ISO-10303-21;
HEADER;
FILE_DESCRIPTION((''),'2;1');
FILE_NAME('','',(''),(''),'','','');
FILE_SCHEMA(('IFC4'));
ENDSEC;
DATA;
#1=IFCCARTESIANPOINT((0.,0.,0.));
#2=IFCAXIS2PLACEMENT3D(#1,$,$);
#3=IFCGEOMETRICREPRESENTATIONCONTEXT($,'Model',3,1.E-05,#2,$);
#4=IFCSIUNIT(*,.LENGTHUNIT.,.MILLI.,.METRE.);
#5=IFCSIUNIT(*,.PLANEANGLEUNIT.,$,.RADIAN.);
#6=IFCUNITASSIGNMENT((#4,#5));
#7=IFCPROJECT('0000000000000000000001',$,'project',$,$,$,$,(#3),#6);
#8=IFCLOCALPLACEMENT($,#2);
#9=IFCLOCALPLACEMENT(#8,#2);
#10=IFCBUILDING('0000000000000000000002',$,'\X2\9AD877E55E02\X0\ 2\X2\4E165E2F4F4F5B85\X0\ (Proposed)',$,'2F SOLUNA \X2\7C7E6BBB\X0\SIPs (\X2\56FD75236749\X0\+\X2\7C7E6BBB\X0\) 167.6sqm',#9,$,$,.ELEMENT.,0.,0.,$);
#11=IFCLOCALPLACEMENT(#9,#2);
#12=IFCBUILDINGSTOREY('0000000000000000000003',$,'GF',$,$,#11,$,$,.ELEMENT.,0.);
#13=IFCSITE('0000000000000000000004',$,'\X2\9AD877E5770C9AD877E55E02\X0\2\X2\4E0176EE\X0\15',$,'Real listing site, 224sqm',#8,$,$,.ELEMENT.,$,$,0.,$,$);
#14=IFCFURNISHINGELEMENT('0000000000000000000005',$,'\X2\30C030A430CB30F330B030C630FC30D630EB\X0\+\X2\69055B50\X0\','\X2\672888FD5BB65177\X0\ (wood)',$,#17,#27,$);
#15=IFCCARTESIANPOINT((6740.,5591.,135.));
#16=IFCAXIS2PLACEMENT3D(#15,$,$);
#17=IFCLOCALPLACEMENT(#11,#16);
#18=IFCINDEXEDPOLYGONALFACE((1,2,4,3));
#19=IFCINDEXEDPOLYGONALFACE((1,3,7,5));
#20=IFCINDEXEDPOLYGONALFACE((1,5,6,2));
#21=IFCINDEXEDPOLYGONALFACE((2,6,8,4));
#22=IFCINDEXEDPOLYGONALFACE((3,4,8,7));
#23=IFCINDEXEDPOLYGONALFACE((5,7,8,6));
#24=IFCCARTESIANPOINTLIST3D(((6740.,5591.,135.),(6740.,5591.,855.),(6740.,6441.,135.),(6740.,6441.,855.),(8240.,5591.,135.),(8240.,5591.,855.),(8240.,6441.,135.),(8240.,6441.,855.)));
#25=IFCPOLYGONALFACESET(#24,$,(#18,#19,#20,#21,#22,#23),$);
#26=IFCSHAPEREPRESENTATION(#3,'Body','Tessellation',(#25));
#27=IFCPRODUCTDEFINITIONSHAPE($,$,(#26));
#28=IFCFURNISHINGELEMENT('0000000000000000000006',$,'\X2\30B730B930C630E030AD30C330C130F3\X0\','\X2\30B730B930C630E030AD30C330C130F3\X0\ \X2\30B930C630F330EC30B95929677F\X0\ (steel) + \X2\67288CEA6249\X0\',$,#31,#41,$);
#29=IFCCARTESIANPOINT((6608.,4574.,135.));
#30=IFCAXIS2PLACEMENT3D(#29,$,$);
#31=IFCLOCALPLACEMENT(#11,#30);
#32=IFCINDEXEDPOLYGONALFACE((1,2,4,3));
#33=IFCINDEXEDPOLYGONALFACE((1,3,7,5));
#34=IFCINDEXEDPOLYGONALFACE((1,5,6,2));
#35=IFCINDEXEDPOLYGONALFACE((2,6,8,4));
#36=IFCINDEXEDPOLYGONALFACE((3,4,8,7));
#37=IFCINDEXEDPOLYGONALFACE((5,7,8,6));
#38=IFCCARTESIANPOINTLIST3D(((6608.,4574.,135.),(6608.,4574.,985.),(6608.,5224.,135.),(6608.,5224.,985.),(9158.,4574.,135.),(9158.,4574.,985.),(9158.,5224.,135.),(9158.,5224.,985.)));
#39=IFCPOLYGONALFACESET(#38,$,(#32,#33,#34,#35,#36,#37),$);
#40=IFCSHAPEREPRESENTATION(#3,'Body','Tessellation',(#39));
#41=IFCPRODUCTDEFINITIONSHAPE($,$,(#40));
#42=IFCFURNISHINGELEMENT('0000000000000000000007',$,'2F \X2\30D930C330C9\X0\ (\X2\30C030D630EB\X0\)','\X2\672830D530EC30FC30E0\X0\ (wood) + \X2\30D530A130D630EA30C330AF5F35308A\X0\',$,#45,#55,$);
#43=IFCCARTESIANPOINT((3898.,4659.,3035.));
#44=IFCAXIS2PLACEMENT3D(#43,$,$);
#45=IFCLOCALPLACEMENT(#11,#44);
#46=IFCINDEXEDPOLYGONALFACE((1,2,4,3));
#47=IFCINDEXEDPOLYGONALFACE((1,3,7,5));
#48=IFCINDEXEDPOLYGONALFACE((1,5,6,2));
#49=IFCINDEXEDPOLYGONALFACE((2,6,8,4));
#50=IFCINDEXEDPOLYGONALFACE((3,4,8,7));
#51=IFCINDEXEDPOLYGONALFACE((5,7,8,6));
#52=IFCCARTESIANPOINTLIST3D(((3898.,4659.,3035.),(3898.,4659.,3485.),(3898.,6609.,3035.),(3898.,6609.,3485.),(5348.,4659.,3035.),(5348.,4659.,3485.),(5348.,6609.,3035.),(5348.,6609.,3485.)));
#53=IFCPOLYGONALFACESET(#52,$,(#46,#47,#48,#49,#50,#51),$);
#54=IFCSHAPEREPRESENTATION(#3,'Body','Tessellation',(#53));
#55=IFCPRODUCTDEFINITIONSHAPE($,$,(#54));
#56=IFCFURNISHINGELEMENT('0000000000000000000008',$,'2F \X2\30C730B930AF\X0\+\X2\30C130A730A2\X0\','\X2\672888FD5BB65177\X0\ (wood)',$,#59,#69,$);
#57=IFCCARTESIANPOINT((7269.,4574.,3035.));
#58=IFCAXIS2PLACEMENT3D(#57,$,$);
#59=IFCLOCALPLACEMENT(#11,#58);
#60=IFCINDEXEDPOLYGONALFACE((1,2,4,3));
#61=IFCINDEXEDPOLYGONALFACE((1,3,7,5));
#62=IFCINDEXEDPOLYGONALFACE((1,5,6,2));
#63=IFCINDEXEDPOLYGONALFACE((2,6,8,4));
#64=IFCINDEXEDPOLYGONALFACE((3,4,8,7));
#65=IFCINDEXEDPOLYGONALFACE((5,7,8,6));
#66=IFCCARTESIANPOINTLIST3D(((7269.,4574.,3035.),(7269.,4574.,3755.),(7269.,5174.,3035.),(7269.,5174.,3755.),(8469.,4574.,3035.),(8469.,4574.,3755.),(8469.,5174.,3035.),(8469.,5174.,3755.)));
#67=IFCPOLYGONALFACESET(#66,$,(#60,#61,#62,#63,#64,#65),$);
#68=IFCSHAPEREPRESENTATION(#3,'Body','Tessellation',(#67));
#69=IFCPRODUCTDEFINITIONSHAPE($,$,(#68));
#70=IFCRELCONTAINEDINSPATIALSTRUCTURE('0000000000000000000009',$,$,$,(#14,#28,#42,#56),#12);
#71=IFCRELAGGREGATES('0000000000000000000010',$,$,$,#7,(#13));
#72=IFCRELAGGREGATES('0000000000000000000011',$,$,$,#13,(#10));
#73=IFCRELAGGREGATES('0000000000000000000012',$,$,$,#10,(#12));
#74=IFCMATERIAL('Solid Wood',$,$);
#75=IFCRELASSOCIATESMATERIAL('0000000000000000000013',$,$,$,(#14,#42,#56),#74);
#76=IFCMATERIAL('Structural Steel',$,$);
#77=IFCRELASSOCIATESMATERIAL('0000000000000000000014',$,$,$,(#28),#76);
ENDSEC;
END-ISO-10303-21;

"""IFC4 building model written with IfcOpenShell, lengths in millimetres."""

from ifc_helpers import new_model, si_unit, frame, frame_2d, origin, place, context, project, spatial, rectangle, extrude, material, element, save


model = new_model("IFC4")

# Units and contexts
model_context = context("Model", 3, precision=1e-05, world=origin())
ifc_project = project(units=[si_unit("LENGTHUNIT", "METRE", prefix="MILLI"), si_unit("PLANEANGLEUNIT", "RADIAN")], contexts=[model_context])

# Site, building, storey
site_placement = place(None, origin())
site = spatial("IfcSite", under=ifc_project, at=site_placement, Name="高知県高知市2丁目15", ObjectType="Real listing site, 224sqm", CompositionType="ELEMENT", RefElevation=0.0)
building_placement = place(site_placement, origin())
building = spatial("IfcBuilding", under=site, at=building_placement, Name="高知市 2世帯住宅 (Proposed)", ObjectType="2F SOLUNA 籾殻SIPs (国産杉+籾殻) 167.6sqm", CompositionType="ELEMENT", ElevationOfRefHeight=0.0, ElevationOfTerrain=0.0)
storey_placement = place(building_placement, origin())
storey = spatial("IfcBuildingStorey", under=building, at=storey_placement, Name="GF", CompositionType="ELEMENT", Elevation=0.0)

# Shared definitions
ifc_material_1 = material(Name="Solid Wood")

# Shared definitions
ifc_material_2 = material(Name="Structural Steel")

# Furnishing elements
furnishing_1_placement = place(storey_placement, frame((6740.0, 5591.0, 135.0)))
element("IfcFurnishingElement", 1, at=furnishing_1_placement, inside=storey, material=ifc_material_1, Name="ダイニングテーブル+椅子", Description="木製家具 (wood)", context=model_context, shape_type="SweptSolid", body=[
    extrude(rectangle(XDim=1500.0, YDim=850.0, at=frame_2d((750.0, 425.0))), frame((6740.0, 5591.0, 135.0)), (0.0, 0.0, 1.0), 720.0),
])
furnishing_2_placement = place(storey_placement, frame((6608.0, 4574.0, 135.0)))
element("IfcFurnishingElement", 2, at=furnishing_2_placement, inside=storey, material=ifc_material_2, Name="システムキッチン", Description="システムキッチン ステンレス天板 (steel) + 木質扉", context=model_context, shape_type="SweptSolid", body=[
    extrude(rectangle(XDim=2550.0, YDim=650.0, at=frame_2d((1275.0, 325.0))), frame((6608.0, 4574.0, 135.0)), (0.0, 0.0, 1.0), 850.0),
])
furnishing_3_placement = place(storey_placement, frame((3898.0, 4659.0, 3035.0)))
element("IfcFurnishingElement", 3, at=furnishing_3_placement, inside=storey, material=ifc_material_1, Name="2F ベッド (ダブル)", Description="木フレーム (wood) + ファブリック張り", context=model_context, shape_type="SweptSolid", body=[
    extrude(rectangle(XDim=1450.0, YDim=1950.0, at=frame_2d((725.0, 975.0))), frame((3898.0, 4659.0, 3035.0)), (0.0, 0.0, 1.0), 450.0),
])
furnishing_4_placement = place(storey_placement, frame((7269.0, 4574.0, 3035.0)))
element("IfcFurnishingElement", 4, at=furnishing_4_placement, inside=storey, material=ifc_material_1, Name="2F デスク+チェア", Description="木製家具 (wood)", context=model_context, shape_type="SweptSolid", body=[
    extrude(rectangle(XDim=1200.0, YDim=600.0, at=frame_2d((600.0, 300.0))), frame((7269.0, 4574.0, 3035.0)), (0.0, 0.0, 1.0), 720.0),
])

save(model, "model.ifc")
